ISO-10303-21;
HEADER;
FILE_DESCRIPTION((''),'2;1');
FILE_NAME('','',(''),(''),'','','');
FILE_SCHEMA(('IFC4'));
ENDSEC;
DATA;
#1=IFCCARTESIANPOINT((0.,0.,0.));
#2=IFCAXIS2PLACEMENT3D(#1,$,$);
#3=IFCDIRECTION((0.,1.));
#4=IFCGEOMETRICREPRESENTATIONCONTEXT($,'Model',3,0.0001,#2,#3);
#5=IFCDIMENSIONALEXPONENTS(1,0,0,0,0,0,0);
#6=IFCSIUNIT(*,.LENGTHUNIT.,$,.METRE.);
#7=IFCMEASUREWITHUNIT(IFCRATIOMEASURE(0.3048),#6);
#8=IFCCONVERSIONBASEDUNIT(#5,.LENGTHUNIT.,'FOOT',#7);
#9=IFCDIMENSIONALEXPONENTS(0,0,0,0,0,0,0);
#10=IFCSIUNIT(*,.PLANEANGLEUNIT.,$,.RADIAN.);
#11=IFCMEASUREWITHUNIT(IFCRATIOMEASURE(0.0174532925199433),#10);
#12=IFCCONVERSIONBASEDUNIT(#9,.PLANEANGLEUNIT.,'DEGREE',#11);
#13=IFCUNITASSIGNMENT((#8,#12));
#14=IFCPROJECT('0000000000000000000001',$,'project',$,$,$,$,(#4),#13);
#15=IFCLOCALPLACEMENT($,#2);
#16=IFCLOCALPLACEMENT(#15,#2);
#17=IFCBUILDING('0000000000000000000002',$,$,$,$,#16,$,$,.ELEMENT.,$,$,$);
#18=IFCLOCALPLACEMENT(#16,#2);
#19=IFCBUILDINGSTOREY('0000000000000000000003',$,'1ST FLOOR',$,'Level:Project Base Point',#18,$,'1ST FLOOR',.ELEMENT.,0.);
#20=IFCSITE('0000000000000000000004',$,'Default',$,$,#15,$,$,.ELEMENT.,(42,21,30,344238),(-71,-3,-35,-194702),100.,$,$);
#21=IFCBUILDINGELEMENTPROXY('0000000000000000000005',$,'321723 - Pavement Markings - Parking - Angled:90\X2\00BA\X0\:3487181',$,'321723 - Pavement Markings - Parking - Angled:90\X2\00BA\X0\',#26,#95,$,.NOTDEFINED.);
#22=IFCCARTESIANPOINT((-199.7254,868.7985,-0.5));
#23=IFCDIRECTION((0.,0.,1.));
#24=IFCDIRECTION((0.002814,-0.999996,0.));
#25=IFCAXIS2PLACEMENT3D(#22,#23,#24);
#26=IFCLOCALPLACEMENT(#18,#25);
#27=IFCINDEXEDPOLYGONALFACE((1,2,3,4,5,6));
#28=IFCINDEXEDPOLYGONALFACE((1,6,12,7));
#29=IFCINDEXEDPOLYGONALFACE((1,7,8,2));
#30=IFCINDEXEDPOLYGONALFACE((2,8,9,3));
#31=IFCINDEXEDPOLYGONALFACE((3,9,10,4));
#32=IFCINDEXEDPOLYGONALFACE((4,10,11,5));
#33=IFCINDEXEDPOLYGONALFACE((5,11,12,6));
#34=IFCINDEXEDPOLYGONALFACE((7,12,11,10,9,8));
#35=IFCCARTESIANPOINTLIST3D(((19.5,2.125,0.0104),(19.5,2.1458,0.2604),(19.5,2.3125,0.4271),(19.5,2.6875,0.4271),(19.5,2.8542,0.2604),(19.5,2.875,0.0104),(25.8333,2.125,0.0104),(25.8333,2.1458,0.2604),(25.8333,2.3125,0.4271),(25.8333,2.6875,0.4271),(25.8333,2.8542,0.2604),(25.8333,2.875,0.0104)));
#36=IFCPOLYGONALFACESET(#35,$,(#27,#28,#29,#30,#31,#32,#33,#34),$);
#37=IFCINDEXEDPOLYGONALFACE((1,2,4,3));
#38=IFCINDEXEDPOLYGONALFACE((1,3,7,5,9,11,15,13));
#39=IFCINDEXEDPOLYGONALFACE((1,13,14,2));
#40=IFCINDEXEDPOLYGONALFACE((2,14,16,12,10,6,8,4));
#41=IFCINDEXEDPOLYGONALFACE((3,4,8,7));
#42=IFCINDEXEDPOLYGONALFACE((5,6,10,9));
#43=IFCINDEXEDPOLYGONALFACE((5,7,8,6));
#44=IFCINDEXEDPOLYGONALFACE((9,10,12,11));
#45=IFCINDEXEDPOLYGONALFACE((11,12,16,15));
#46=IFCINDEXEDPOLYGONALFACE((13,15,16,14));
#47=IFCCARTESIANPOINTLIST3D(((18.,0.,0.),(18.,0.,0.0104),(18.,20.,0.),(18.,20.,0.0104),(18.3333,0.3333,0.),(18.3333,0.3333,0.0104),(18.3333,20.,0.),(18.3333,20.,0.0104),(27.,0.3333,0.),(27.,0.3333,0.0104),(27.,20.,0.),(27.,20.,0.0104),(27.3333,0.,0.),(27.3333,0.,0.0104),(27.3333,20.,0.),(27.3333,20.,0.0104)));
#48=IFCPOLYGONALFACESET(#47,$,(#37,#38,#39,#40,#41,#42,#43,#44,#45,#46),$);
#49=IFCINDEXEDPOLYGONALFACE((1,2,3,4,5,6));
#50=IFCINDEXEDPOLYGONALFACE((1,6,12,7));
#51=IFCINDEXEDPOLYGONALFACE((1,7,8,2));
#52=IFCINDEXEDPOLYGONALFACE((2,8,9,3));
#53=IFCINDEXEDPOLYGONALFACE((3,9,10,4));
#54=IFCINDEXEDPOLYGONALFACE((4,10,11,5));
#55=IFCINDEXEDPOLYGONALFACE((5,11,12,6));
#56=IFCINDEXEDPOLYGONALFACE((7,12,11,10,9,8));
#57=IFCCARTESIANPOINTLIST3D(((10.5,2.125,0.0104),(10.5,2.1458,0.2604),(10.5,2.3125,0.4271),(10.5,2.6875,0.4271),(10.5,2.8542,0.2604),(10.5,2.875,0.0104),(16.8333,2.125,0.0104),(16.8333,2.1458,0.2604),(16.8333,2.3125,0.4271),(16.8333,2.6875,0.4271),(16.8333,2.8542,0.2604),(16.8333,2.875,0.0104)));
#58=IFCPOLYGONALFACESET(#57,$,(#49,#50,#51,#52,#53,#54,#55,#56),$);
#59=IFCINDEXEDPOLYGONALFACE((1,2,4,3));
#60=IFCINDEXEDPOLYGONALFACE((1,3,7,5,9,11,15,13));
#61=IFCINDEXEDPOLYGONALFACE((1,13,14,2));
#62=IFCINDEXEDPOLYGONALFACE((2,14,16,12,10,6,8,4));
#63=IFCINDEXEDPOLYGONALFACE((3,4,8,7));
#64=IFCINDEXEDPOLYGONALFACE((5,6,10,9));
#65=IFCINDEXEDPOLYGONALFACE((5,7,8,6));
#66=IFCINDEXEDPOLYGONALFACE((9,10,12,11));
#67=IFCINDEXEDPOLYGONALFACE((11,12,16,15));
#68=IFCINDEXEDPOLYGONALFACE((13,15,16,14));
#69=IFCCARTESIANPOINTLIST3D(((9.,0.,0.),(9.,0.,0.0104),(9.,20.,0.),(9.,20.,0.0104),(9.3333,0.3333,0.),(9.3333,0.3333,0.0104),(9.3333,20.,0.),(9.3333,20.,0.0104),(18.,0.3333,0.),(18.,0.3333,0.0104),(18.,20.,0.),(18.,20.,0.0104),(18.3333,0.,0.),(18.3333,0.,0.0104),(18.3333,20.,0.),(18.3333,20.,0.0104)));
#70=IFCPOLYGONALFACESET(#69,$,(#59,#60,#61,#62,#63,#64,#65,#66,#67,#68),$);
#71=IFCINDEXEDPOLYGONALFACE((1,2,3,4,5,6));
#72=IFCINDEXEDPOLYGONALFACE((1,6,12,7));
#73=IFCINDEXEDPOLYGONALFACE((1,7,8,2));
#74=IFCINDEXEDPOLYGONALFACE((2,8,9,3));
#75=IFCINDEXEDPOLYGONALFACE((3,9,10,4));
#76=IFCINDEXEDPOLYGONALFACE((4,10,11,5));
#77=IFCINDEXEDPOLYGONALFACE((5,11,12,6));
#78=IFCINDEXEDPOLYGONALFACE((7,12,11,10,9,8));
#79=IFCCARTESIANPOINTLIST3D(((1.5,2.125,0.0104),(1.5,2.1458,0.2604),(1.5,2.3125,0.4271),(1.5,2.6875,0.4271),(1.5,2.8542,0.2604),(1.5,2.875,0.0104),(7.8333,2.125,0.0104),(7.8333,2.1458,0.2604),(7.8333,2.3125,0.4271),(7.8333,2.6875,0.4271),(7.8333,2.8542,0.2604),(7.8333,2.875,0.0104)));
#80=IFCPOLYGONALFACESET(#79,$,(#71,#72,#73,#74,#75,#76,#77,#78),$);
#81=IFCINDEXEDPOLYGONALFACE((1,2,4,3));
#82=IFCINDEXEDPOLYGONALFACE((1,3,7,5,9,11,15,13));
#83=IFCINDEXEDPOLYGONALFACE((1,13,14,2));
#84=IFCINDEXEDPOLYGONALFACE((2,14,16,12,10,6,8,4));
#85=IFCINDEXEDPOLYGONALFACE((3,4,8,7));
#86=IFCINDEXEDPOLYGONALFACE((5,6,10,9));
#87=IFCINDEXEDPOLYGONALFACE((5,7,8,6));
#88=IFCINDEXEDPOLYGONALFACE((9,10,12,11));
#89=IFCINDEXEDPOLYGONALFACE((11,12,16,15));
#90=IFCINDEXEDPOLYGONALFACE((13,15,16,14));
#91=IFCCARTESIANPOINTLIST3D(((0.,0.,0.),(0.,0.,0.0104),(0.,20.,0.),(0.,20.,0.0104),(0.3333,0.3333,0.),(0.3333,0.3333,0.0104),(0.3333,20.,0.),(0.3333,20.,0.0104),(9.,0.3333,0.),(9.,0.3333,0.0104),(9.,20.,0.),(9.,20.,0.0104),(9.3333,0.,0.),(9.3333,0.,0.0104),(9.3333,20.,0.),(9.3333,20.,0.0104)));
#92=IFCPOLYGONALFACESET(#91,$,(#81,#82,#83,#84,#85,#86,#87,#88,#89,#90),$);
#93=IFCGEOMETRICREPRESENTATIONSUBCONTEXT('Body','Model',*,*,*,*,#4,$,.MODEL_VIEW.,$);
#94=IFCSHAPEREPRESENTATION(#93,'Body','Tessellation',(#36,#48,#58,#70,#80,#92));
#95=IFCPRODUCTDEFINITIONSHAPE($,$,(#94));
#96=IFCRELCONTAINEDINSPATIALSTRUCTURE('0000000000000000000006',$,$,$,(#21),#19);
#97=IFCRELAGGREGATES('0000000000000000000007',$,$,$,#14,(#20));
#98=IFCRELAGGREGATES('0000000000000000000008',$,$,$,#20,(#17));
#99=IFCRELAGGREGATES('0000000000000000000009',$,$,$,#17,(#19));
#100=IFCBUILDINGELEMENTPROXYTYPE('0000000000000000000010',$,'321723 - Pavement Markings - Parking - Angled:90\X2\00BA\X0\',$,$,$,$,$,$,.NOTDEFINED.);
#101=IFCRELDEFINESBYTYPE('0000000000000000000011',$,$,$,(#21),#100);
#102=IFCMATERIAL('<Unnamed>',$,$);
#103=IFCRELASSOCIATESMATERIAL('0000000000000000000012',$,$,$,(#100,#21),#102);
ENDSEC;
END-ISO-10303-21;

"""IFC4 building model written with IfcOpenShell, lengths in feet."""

from ifc_helpers import new_model, entity, si_unit, converted_unit, direction, frame, origin, place, context, subcontext, project, spatial, polyline, outline, extrude, source, transform, mapped, material, type_object, type_shapes, element, save


model = new_model("IFC4")

# Units and contexts
model_context = context("Model", 3, precision=0.0001, world=origin(), true_north=direction((0.0, 1.0)))
body_context = subcontext(model_context, "Body", "Model", "MODEL_VIEW")
ifc_project = project(units=[converted_unit("LENGTHUNIT", "FOOT", entity("IfcRatioMeasure", 0.3048), si_unit("LENGTHUNIT", "METRE"), dimensions=[1, 0, 0, 0, 0, 0, 0]), converted_unit("PLANEANGLEUNIT", "DEGREE", entity("IfcRatioMeasure", 0.0174532925199433), si_unit("PLANEANGLEUNIT", "RADIAN"), dimensions=[0, 0, 0, 0, 0, 0, 0])], contexts=[model_context])

# Site, building, storey
site_placement = place(None, origin())
site = spatial("IfcSite", under=ifc_project, at=site_placement, Name="Default", CompositionType="ELEMENT", RefLatitude=(42, 21, 30, 344238), RefLongitude=(-71, -3, -35, -194702), RefElevation=100.0)
building_placement = place(site_placement, origin())
building = spatial("IfcBuilding", under=site, at=building_placement, CompositionType="ELEMENT")
storey_placement = place(building_placement, origin())
storey = spatial("IfcBuildingStorey", under=building, at=storey_placement, Name="1ST FLOOR", ObjectType="Level:Project Base Point", LongName="1ST FLOOR", CompositionType="ELEMENT", Elevation=0.0)

# Building element proxy
ifc_material_1 = material(Name="<Unnamed>")
building_element_proxy_type_1 = type_object("IfcBuildingElementProxyType", Name="321723 - Pavement Markings - Parking - Angled:90º", PredefinedType="NOTDEFINED", material=ifc_material_1)
shared_shape_1 = source(origin(), body_context, "Body", "SweptSolid", [
    extrude(outline(polyline([(-0.375, -0.2222), (0.375, -0.2222), (0.3542, 0.0278), (0.1875, 0.1944), (-0.1875, 0.1944), (-0.3542, 0.0278), (-0.375, -0.2222)])), frame((19.5, 2.5, 0.2326), z_axis=(1.0, 0.0, 0.0), x_axis=(0.0, 1.0, 0.0)), (0.0, 0.0, 1.0), 6.3333),
    extrude(outline(polyline([(-4.6667, -10.0833), (4.6667, -10.0833), (4.6667, 9.9167), (4.3333, 9.9167), (4.3333, -9.75), (-4.3333, -9.75), (-4.3333, 9.9167), (-4.6667, 9.9167), (-4.6667, -10.0833)])), frame((22.6667, 10.0833, 0.0)), (0.0, 0.0, 1.0), 0.0104),
    extrude(outline(polyline([(-0.375, -0.2222), (0.375, -0.2222), (0.3542, 0.0278), (0.1875, 0.1944), (-0.1875, 0.1944), (-0.3542, 0.0278), (-0.375, -0.2222)])), frame((10.5, 2.5, 0.2326), z_axis=(1.0, 0.0, 0.0), x_axis=(0.0, 1.0, 0.0)), (0.0, 0.0, 1.0), 6.3333),
    extrude(outline(polyline([(-4.6667, -10.0833), (4.6667, -10.0833), (4.6667, 9.9167), (4.3333, 9.9167), (4.3333, -9.75), (-4.3333, -9.75), (-4.3333, 9.9167), (-4.6667, 9.9167), (-4.6667, -10.0833)])), frame((13.6667, 10.0833, 0.0)), (0.0, 0.0, 1.0), 0.0104),
    extrude(outline(polyline([(-0.375, -0.2222), (0.375, -0.2222), (0.3542, 0.0278), (0.1875, 0.1944), (-0.1875, 0.1944), (-0.3542, 0.0278), (-0.375, -0.2222)])), frame((1.5, 2.5, 0.2326), z_axis=(1.0, 0.0, 0.0), x_axis=(0.0, 1.0, 0.0)), (0.0, 0.0, 1.0), 6.3333),
    extrude(outline(polyline([(-4.6667, -10.0833), (4.6667, -10.0833), (4.6667, 9.9167), (4.3333, 9.9167), (4.3333, -9.75), (-4.3333, -9.75), (-4.3333, 9.9167), (-4.6667, 9.9167), (-4.6667, -10.0833)])), frame((4.6667, 10.0833, 0.0)), (0.0, 0.0, 1.0), 0.0104),
])
type_shapes(building_element_proxy_type_1, [shared_shape_1])
proxy_1_placement = place(storey_placement, frame((-199.7254, 868.7985, -0.5), z_axis=(0.0, 0.0, 1.0), x_axis=(0.002814, -0.999996, 0.0)))
element("IfcBuildingElementProxy", 1, at=proxy_1_placement, inside=storey, type_object=building_element_proxy_type_1, material=ifc_material_1, Name="321723 - Pavement Markings - Parking - Angled:90º:3487181", ObjectType="321723 - Pavement Markings - Parking - Angled:90º", PredefinedType="NOTDEFINED", context=body_context, shape_type="MappedRepresentation", body=[
    mapped(shared_shape_1, transform((0.0, 0.0, 0.0), scale=1.0)),
])

save(model, "model.ifc")
